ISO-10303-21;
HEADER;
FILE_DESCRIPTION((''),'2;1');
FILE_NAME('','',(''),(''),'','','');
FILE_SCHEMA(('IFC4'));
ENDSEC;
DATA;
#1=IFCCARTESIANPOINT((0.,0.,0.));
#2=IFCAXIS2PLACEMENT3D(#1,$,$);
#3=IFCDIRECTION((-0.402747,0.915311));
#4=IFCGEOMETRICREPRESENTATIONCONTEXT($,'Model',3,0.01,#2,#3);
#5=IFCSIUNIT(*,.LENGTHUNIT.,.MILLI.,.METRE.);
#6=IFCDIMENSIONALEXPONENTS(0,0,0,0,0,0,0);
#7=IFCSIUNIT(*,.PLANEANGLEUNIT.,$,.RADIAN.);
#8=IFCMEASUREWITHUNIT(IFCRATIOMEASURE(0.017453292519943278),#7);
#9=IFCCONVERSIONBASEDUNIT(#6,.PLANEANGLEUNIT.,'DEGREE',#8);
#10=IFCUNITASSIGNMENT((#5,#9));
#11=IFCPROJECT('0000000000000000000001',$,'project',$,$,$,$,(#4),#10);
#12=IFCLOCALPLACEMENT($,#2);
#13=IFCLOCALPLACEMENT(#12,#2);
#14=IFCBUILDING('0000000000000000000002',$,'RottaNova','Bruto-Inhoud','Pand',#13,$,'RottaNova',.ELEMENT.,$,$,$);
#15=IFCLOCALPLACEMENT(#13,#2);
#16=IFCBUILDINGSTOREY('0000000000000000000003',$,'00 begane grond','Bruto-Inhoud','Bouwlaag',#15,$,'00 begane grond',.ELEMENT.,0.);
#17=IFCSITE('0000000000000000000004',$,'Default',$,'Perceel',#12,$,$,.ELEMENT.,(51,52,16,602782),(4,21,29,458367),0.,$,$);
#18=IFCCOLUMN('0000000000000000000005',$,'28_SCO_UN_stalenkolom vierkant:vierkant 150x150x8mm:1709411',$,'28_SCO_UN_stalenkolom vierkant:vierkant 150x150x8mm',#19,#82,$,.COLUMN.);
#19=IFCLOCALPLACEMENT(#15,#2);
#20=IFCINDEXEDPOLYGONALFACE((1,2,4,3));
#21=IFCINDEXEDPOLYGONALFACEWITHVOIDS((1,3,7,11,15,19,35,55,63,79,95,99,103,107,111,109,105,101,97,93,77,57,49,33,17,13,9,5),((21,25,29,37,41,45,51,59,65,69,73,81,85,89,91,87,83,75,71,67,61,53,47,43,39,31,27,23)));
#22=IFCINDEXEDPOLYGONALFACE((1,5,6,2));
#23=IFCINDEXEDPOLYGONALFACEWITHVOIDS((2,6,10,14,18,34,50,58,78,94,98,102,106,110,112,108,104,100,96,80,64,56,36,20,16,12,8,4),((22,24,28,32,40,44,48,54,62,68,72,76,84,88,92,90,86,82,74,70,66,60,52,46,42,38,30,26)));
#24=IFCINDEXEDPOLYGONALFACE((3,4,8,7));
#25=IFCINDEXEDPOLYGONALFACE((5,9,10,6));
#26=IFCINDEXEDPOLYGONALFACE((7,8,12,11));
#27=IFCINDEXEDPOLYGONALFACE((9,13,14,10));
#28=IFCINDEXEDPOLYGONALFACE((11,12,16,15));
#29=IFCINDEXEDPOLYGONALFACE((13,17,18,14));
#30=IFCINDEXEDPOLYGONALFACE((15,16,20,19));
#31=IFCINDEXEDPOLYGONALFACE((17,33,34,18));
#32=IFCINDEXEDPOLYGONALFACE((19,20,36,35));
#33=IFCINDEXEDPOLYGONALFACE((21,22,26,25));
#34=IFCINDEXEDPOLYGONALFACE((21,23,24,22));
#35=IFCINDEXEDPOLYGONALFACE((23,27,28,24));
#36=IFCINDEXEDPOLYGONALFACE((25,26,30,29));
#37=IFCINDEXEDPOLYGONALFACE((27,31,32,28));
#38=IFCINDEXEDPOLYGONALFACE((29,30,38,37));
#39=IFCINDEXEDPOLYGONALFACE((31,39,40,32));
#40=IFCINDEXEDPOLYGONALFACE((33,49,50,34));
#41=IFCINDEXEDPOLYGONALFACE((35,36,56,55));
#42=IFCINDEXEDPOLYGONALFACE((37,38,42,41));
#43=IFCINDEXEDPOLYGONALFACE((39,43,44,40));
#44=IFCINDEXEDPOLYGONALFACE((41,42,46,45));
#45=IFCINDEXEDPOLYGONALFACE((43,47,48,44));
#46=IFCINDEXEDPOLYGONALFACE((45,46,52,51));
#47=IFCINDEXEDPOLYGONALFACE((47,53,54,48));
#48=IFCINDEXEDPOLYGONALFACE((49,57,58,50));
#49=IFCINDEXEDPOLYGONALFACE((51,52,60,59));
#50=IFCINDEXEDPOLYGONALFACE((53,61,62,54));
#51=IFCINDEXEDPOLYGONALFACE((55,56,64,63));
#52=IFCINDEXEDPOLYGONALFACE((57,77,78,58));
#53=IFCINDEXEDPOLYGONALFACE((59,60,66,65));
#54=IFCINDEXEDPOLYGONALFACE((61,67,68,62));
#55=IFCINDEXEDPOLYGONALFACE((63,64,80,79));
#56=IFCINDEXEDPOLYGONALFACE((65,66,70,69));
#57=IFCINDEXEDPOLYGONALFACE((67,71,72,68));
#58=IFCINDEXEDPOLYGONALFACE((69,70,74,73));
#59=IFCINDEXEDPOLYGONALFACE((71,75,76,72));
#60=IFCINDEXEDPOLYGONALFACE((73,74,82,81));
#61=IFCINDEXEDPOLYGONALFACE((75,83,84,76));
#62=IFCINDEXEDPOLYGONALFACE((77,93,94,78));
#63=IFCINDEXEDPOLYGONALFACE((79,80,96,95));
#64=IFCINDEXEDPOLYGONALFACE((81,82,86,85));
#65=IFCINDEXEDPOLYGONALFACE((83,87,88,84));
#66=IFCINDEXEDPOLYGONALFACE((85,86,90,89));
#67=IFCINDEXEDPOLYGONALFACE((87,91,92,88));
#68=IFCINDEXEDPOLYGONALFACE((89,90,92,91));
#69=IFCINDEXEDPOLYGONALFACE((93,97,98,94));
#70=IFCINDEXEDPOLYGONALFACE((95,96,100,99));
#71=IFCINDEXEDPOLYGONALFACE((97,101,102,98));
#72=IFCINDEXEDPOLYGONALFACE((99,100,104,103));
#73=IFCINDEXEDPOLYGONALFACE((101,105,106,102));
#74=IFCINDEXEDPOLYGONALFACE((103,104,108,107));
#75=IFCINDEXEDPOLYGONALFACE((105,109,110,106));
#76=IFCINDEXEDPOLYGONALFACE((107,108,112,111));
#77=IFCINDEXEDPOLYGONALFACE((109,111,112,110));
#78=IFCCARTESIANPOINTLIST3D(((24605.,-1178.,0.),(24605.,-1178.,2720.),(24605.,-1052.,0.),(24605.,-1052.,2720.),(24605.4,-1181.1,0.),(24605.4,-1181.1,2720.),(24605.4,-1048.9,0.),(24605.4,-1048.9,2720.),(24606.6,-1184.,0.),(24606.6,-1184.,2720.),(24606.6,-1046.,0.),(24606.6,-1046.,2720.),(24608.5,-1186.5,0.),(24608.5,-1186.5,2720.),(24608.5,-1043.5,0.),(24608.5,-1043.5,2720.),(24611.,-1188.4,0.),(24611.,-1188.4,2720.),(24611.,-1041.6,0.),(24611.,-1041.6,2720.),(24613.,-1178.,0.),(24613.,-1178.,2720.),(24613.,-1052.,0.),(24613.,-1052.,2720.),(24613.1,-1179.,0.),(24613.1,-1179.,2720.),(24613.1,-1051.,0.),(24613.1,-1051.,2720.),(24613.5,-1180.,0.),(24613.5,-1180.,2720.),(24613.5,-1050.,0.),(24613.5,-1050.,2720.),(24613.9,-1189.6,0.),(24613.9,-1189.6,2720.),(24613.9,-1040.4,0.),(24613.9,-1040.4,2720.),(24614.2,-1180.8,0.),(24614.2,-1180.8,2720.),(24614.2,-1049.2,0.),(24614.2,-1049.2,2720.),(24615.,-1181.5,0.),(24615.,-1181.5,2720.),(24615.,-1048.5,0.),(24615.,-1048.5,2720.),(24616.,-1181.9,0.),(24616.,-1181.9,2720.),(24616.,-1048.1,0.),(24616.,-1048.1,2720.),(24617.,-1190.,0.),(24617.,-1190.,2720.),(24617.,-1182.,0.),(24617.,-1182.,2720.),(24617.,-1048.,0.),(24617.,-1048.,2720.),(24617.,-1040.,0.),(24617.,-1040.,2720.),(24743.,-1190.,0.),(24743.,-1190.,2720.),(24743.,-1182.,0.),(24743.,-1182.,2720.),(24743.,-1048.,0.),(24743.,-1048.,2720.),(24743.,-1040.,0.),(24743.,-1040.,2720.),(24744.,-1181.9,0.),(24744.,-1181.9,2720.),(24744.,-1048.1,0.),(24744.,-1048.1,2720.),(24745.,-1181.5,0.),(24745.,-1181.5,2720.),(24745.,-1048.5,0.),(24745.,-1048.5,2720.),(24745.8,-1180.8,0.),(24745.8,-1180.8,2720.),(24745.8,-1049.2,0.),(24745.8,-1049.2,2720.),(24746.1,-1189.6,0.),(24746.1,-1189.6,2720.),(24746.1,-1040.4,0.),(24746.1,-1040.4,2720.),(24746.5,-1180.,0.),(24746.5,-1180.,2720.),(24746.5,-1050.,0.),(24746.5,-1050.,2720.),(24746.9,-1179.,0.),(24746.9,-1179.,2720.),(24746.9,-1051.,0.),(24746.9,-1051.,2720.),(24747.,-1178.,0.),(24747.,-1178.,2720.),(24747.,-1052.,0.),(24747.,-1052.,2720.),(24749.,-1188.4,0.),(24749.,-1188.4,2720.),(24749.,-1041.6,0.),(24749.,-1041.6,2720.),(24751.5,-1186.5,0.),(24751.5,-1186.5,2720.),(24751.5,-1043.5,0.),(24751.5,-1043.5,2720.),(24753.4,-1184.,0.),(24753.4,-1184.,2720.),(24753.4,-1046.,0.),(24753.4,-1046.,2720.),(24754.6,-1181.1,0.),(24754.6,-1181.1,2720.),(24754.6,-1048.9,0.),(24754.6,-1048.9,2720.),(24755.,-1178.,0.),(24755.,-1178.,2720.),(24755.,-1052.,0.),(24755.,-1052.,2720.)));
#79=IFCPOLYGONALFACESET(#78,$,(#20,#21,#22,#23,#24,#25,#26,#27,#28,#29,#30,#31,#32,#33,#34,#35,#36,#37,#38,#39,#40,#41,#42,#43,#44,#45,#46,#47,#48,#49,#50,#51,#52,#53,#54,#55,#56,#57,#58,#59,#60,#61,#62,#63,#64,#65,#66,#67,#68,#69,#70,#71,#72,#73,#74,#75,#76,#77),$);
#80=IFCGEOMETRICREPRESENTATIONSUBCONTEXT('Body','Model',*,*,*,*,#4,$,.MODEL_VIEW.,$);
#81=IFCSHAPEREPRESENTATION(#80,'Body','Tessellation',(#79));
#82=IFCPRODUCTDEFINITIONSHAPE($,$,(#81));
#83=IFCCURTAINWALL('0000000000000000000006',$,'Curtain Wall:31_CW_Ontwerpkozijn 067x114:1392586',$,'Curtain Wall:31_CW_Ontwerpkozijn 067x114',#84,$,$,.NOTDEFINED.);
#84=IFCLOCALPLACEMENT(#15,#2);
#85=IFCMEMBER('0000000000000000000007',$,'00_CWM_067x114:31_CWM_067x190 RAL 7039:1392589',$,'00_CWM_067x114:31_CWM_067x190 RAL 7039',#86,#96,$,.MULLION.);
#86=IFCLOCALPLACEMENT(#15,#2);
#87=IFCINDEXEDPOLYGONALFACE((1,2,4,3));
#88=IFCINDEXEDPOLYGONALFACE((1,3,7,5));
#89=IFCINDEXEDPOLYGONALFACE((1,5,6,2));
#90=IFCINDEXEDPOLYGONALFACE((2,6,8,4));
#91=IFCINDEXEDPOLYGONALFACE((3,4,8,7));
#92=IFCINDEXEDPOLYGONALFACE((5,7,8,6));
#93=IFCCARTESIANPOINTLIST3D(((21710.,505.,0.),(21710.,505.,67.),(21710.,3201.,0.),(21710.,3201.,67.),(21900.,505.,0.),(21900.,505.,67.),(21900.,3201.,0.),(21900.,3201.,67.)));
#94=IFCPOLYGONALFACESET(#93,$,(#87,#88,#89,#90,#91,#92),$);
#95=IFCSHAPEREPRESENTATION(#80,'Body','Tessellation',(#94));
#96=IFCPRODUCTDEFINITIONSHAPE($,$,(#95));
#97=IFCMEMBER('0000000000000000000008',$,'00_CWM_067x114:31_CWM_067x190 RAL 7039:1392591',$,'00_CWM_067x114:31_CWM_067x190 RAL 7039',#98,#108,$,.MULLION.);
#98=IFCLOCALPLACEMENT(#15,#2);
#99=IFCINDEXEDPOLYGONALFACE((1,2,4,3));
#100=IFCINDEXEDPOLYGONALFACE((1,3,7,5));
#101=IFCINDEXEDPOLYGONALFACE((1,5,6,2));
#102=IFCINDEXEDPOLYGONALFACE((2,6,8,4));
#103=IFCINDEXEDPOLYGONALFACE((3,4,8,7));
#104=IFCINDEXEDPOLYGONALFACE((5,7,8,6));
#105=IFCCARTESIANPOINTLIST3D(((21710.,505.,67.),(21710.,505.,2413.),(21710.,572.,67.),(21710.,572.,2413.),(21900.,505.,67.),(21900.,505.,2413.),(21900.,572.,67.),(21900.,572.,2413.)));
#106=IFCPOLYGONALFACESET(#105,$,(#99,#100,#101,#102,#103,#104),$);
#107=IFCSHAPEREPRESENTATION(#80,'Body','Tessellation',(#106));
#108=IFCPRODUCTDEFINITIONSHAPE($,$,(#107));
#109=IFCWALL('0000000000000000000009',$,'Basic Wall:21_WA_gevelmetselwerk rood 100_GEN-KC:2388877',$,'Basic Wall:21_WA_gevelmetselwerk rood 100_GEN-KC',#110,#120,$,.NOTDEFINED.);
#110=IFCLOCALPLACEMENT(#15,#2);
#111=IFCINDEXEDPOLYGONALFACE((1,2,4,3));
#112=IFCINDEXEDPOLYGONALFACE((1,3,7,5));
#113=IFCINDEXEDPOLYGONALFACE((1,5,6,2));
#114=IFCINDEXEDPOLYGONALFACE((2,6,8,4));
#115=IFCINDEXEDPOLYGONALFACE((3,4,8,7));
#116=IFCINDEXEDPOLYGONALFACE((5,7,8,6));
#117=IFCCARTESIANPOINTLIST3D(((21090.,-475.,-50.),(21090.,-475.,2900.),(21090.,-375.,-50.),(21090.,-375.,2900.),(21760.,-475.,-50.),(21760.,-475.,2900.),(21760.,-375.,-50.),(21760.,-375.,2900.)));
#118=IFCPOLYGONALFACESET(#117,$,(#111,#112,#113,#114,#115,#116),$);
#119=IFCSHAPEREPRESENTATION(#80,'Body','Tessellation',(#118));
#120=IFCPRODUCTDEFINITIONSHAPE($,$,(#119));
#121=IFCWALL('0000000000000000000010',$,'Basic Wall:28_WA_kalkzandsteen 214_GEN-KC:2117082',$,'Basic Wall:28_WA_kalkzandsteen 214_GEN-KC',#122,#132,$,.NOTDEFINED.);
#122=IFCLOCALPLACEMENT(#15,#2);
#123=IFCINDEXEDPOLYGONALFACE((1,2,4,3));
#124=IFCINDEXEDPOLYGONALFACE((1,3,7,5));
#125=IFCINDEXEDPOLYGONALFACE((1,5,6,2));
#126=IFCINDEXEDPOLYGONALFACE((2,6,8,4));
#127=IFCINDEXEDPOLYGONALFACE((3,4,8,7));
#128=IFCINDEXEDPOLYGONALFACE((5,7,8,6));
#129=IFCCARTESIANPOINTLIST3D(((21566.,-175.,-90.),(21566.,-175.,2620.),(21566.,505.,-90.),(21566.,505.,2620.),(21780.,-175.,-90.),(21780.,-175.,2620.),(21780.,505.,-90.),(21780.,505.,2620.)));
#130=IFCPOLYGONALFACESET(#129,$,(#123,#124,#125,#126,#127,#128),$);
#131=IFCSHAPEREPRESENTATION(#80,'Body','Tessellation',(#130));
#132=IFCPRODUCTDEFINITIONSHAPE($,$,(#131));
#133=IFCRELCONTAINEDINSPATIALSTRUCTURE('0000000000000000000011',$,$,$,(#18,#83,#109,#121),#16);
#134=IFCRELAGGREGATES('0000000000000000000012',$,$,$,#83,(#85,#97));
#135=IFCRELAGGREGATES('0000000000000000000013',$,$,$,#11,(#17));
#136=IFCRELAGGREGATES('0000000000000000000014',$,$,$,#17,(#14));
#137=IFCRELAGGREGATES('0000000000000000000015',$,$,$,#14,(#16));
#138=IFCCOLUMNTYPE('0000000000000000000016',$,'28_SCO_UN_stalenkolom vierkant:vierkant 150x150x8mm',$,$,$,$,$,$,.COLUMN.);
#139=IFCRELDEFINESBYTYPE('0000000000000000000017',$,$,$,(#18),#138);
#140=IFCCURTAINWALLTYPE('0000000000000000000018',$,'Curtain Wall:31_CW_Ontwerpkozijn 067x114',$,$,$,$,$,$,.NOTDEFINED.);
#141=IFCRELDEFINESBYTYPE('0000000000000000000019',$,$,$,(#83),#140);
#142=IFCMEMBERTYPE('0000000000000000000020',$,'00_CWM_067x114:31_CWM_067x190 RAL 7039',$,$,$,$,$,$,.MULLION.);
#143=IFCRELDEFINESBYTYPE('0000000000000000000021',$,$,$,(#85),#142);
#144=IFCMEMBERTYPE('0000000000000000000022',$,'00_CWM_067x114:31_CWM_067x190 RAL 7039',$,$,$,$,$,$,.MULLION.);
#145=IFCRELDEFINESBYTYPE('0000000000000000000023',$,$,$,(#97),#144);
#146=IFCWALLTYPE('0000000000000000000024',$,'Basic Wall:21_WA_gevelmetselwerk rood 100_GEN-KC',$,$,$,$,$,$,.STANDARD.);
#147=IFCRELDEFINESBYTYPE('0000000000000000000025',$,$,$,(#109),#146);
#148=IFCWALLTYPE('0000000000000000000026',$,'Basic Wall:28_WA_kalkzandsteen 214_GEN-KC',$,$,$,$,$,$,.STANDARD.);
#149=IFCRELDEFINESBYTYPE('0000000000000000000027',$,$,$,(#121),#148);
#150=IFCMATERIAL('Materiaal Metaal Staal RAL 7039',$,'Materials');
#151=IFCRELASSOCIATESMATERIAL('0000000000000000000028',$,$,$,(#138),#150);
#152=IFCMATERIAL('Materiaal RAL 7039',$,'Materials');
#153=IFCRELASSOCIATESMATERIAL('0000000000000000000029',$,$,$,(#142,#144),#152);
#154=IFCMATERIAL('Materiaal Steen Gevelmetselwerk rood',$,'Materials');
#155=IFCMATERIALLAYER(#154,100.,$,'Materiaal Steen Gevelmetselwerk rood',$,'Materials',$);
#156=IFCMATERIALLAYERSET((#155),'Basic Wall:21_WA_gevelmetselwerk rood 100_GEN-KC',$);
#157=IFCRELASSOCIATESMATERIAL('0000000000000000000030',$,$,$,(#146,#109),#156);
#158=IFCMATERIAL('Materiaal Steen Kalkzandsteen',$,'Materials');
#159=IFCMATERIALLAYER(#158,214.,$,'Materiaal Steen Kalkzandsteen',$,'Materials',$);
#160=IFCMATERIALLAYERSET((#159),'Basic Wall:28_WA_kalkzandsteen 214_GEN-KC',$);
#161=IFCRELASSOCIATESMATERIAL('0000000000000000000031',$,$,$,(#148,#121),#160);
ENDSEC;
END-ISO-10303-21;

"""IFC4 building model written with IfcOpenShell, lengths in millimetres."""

from ifc_helpers import new_model, entity, si_unit, converted_unit, direction, frame, frame_2d, origin, origin_2d_with_axis, place, context, subcontext, project, spatial, polyline, circle_curve, parameter, trimmed, segment, composite_curve, rectangle, outline, extrude, source, transform, mapped, material, layer, layer_set, material_profile, profile_set, type_object, type_shapes, element, aggregate, save


model = new_model("IFC4")

# Units and contexts
model_context = context("Model", 3, precision=0.01, world=origin(), true_north=direction((-0.402747, 0.915311)))
body_context = subcontext(model_context, "Body", "Model", "MODEL_VIEW")
ifc_project = project(units=[si_unit("LENGTHUNIT", "METRE", prefix="MILLI"), converted_unit("PLANEANGLEUNIT", "DEGREE", entity("IfcRatioMeasure", 0.017453292519943278), si_unit("PLANEANGLEUNIT", "RADIAN"), dimensions=[0, 0, 0, 0, 0, 0, 0])], contexts=[model_context])

# Site, building, storey
site_placement = place(None, origin())
site = spatial("IfcSite", under=ifc_project, at=site_placement, Name="Default", ObjectType="Perceel", CompositionType="ELEMENT", RefLatitude=(51, 52, 16, 602782), RefLongitude=(4, 21, 29, 458367), RefElevation=0.0)
building_placement = place(site_placement, origin())
building = spatial("IfcBuilding", under=site, at=building_placement, Name="RottaNova", Description="Bruto-Inhoud", ObjectType="Pand", LongName="RottaNova", CompositionType="ELEMENT")
storey_placement = place(building_placement, origin())
storey = spatial("IfcBuildingStorey", under=building, at=storey_placement, Name="00 begane grond", Description="Bruto-Inhoud", ObjectType="Bouwlaag", LongName="00 begane grond", CompositionType="ELEMENT", Elevation=0.0)

# Column
ifc_material_1 = material(Name="Materiaal Metaal Staal RAL 7039", Category="Materials")
ifc_material_profile_1 = material_profile(ifc_material_1, outline(composite_curve([segment(trimmed(circle_curve(frame_2d((63.0, -63.0), x_axis=(1.0, 0.0)), 12.0), [parameter(270.0)], [parameter(360.0)], True, "PARAMETER"), True, "CONTINUOUS"), segment(polyline([(75.0, -63.0), (75.0, 63.0)]), True, "CONTINUOUS"), segment(trimmed(circle_curve(frame_2d((63.0, 63.0), x_axis=(1.0, 0.0)), 12.0), [parameter(360.0)], [parameter(90.0)], True, "PARAMETER"), True, "CONTINUOUS"), segment(polyline([(63.0, 75.0), (-63.0, 75.0)]), True, "CONTINUOUS"), segment(trimmed(circle_curve(frame_2d((-63.0, 63.0), x_axis=(1.0, 0.0)), 12.0), [parameter(90.0)], [parameter(180.0)], True, "PARAMETER"), True, "CONTINUOUS"), segment(polyline([(-75.0, 63.0), (-75.0, -63.0)]), True, "CONTINUOUS"), segment(trimmed(circle_curve(frame_2d((-63.0, -63.0), x_axis=(1.0, 0.0)), 12.0), [parameter(180.0)], [parameter(270.0)], True, "PARAMETER"), True, "CONTINUOUS"), segment(polyline([(-63.0, -75.0), (63.0, -75.0)]), True, "CONTINUOUS")], self_intersect=False), holes=[composite_curve([segment(polyline([(-67.0, -63.0), (-67.0, 63.0)]), True, "CONTINUOUS"), segment(trimmed(circle_curve(frame_2d((-63.0, 63.0), x_axis=(1.0, 0.0)), 4.0), [parameter(90.0)], [parameter(180.0)], True, "PARAMETER"), False, "CONTINUOUS"), segment(polyline([(-63.0, 67.0), (63.0, 67.0)]), True, "CONTINUOUS"), segment(trimmed(circle_curve(frame_2d((63.0, 63.0), x_axis=(1.0, 0.0)), 4.0), [parameter(0.0)], [parameter(90.0)], True, "PARAMETER"), False, "CONTINUOUS"), segment(polyline([(67.0, 63.0), (67.0, -63.0)]), True, "CONTINUOUS"), segment(trimmed(circle_curve(frame_2d((63.0, -63.0), x_axis=(1.0, 0.0)), 4.0), [parameter(270.0)], [parameter(0.0)], True, "PARAMETER"), False, "CONTINUOUS"), segment(polyline([(63.0, -67.0), (-63.0, -67.0)]), True, "CONTINUOUS"), segment(trimmed(circle_curve(frame_2d((-63.0, -63.0), x_axis=(1.0, 0.0)), 4.0), [parameter(180.0)], [parameter(270.0)], True, "PARAMETER"), False, "CONTINUOUS")], self_intersect=False)]), Name="vierkant 150x150x8mm")
ifc_profile_set_1 = profile_set([ifc_material_profile_1], Name="vierkant 150x150x8mm")
column_type = type_object("IfcColumnType", Name="28_SCO_UN_stalenkolom vierkant:vierkant 150x150x8mm", PredefinedType="COLUMN", material=ifc_profile_set_1)
shared_shape_1 = source(origin(), body_context, "Body", "SweptSolid", [
    extrude(outline(composite_curve([segment(trimmed(circle_curve(frame_2d((63.0, -63.0), x_axis=(1.0, 0.0)), 12.0), [parameter(270.0)], [parameter(360.0)], True, "PARAMETER"), True, "CONTINUOUS"), segment(polyline([(75.0, -63.0), (75.0, 63.0)]), True, "CONTINUOUS"), segment(trimmed(circle_curve(frame_2d((63.0, 63.0), x_axis=(1.0, 0.0)), 12.0), [parameter(360.0)], [parameter(90.0)], True, "PARAMETER"), True, "CONTINUOUS"), segment(polyline([(63.0, 75.0), (-63.0, 75.0)]), True, "CONTINUOUS"), segment(trimmed(circle_curve(frame_2d((-63.0, 63.0), x_axis=(1.0, 0.0)), 12.0), [parameter(90.0)], [parameter(180.0)], True, "PARAMETER"), True, "CONTINUOUS"), segment(polyline([(-75.0, 63.0), (-75.0, -63.0)]), True, "CONTINUOUS"), segment(trimmed(circle_curve(frame_2d((-63.0, -63.0), x_axis=(1.0, 0.0)), 12.0), [parameter(180.0)], [parameter(270.0)], True, "PARAMETER"), True, "CONTINUOUS"), segment(polyline([(-63.0, -75.0), (63.0, -75.0)]), True, "CONTINUOUS")], self_intersect=False), holes=[composite_curve([segment(polyline([(-67.0, -63.0), (-67.0, 63.0)]), True, "CONTINUOUS"), segment(trimmed(circle_curve(frame_2d((-63.0, 63.0), x_axis=(1.0, 0.0)), 4.0), [parameter(90.0)], [parameter(180.0)], True, "PARAMETER"), False, "CONTINUOUS"), segment(polyline([(-63.0, 67.0), (63.0, 67.0)]), True, "CONTINUOUS"), segment(trimmed(circle_curve(frame_2d((63.0, 63.0), x_axis=(1.0, 0.0)), 4.0), [parameter(0.0)], [parameter(90.0)], True, "PARAMETER"), False, "CONTINUOUS"), segment(polyline([(67.0, 63.0), (67.0, -63.0)]), True, "CONTINUOUS"), segment(trimmed(circle_curve(frame_2d((63.0, -63.0), x_axis=(1.0, 0.0)), 4.0), [parameter(270.0)], [parameter(0.0)], True, "PARAMETER"), False, "CONTINUOUS"), segment(polyline([(63.0, -67.0), (-63.0, -67.0)]), True, "CONTINUOUS"), segment(trimmed(circle_curve(frame_2d((-63.0, -63.0), x_axis=(1.0, 0.0)), 4.0), [parameter(180.0)], [parameter(270.0)], True, "PARAMETER"), False, "CONTINUOUS")], self_intersect=False)]), origin(), (0.0, 0.0, 1.0), 2720.0),
])
type_shapes(column_type, [shared_shape_1])
column_placement = place(storey_placement, frame((24680.0, -1115.0, 0.0)))
element("IfcColumn", 1, at=column_placement, inside=storey, type_object=column_type, Name="28_SCO_UN_stalenkolom vierkant:vierkant 150x150x8mm:1709411", ObjectType="28_SCO_UN_stalenkolom vierkant:vierkant 150x150x8mm", PredefinedType="COLUMN", context=body_context, shape_type="MappedRepresentation", body=[
    mapped(shared_shape_1, transform((0.0, 0.0, 0.0), scale=1.0)),
])

# Curtain wall, members
curtain_wall_type = type_object("IfcCurtainWallType", Name="Curtain Wall:31_CW_Ontwerpkozijn 067x114", PredefinedType="NOTDEFINED")
curtain_wall_placement = place(storey_placement, origin())
curtain_wall = element("IfcCurtainWall", 2, at=curtain_wall_placement, inside=storey, type_object=curtain_wall_type, Name="Curtain Wall:31_CW_Ontwerpkozijn 067x114:1392586", ObjectType="Curtain Wall:31_CW_Ontwerpkozijn 067x114", PredefinedType="NOTDEFINED")
ifc_material_2 = material(Name="Materiaal RAL 7039", Category="Materials")
ifc_material_profile_2 = material_profile(ifc_material_2, rectangle(XDim=190.0, YDim=67.0, at=origin_2d_with_axis()), Name="31_CWM_067x190 RAL 7039")
ifc_profile_set_2 = profile_set([ifc_material_profile_2], Name="31_CWM_067x190 RAL 7039")
member_type_1 = type_object("IfcMemberType", Name="00_CWM_067x114:31_CWM_067x190 RAL 7039", PredefinedType="MULLION", material=ifc_profile_set_2)
shared_shape_2 = source(origin(), body_context, "Body", "SweptSolid", [
    extrude(rectangle(XDim=190.0, YDim=67.0, at=origin_2d_with_axis()), frame((-33.5, 95.0, -2696.0), z_axis=(0.0, 0.0, 1.0), x_axis=(0.0, -1.0, 0.0)), (0.0, 0.0, 1.0), 2696.0),
])
type_shapes(member_type_1, [shared_shape_2])
member_1_placement = place(curtain_wall_placement, frame((21710.0, 505.0, 0.0), z_axis=(0.0, -1.0, 0.0), x_axis=(0.0, 0.0, -1.0)))
member_1 = element("IfcMember", 3, at=member_1_placement, type_object=member_type_1, Name="00_CWM_067x114:31_CWM_067x190 RAL 7039:1392589", ObjectType="00_CWM_067x114:31_CWM_067x190 RAL 7039", PredefinedType="MULLION", context=body_context, shape_type="MappedRepresentation", body=[
    mapped(shared_shape_2, transform((0.0, 0.0, 0.0), scale=1.0)),
])
member_type_2 = type_object("IfcMemberType", Name="00_CWM_067x114:31_CWM_067x190 RAL 7039", PredefinedType="MULLION", material=ifc_profile_set_2)
shared_shape_3 = source(origin(), body_context, "Body", "SweptSolid", [
    extrude(rectangle(XDim=190.0, YDim=67.0, at=origin_2d_with_axis()), frame((-33.5, 95.0, -2346.0), z_axis=(0.0, 0.0, 1.0), x_axis=(0.0, -1.0, 0.0)), (0.0, 0.0, 1.0), 2346.0),
])
type_shapes(member_type_2, [shared_shape_3])
member_2_placement = place(curtain_wall_placement, frame((21710.0, 505.0, 2413.0), z_axis=(0.0, 0.0, 1.0), x_axis=(0.0, -1.0, 0.0)))
member_2 = element("IfcMember", 4, at=member_2_placement, type_object=member_type_2, Name="00_CWM_067x114:31_CWM_067x190 RAL 7039:1392591", ObjectType="00_CWM_067x114:31_CWM_067x190 RAL 7039", PredefinedType="MULLION", context=body_context, shape_type="MappedRepresentation", body=[
    mapped(shared_shape_3, transform((0.0, 0.0, 0.0), scale=1.0)),
])

# Walls
ifc_material_3 = material(Name="Materiaal Steen Gevelmetselwerk rood", Category="Materials")
ifc_layer_1 = layer(ifc_material_3, 100.0, Name="Materiaal Steen Gevelmetselwerk rood", Category="Materials")
ifc_layer_set_1 = layer_set([ifc_layer_1], Name="Basic Wall:21_WA_gevelmetselwerk rood 100_GEN-KC")
wall_type_1 = type_object("IfcWallType", Name="Basic Wall:21_WA_gevelmetselwerk rood 100_GEN-KC", PredefinedType="STANDARD", material=ifc_layer_set_1)
wall_1_placement = place(storey_placement, frame((21760.0, -425.0, -50.0), z_axis=(0.0, 0.0, 1.0), x_axis=(-1.0, 0.0, 0.0)))
element("IfcWall", 5, at=wall_1_placement, inside=storey, type_object=wall_type_1, material=ifc_layer_set_1, Name="Basic Wall:21_WA_gevelmetselwerk rood 100_GEN-KC:2388877", ObjectType="Basic Wall:21_WA_gevelmetselwerk rood 100_GEN-KC", PredefinedType="NOTDEFINED", context=body_context, shape_type="SweptSolid", body=[
    extrude(rectangle(XDim=670.0, YDim=100.0, at=frame_2d((335.0, 0.0), x_axis=(-1.0, 0.0))), origin(), (0.0, 0.0, 1.0), 2950.0),
])
ifc_material_4 = material(Name="Materiaal Steen Kalkzandsteen", Category="Materials")
ifc_layer_2 = layer(ifc_material_4, 214.0, Name="Materiaal Steen Kalkzandsteen", Category="Materials")
ifc_layer_set_2 = layer_set([ifc_layer_2], Name="Basic Wall:28_WA_kalkzandsteen 214_GEN-KC")
wall_type_2 = type_object("IfcWallType", Name="Basic Wall:28_WA_kalkzandsteen 214_GEN-KC", PredefinedType="STANDARD", material=ifc_layer_set_2)
wall_2_placement = place(storey_placement, frame((21673.0, -175.0, -90.0), z_axis=(0.0, 0.0, 1.0), x_axis=(0.0, 1.0, 0.0)))
element("IfcWall", 6, at=wall_2_placement, inside=storey, type_object=wall_type_2, material=ifc_layer_set_2, Name="Basic Wall:28_WA_kalkzandsteen 214_GEN-KC:2117082", ObjectType="Basic Wall:28_WA_kalkzandsteen 214_GEN-KC", PredefinedType="NOTDEFINED", context=body_context, shape_type="SweptSolid", body=[
    extrude(rectangle(XDim=680.0, YDim=214.0, at=frame_2d((340.0, 0.0), x_axis=(-1.0, 0.0))), origin(), (0.0, 0.0, 1.0), 2710.0),
])

aggregate(curtain_wall, [member_1, member_2])

save(model, "model.ifc")
